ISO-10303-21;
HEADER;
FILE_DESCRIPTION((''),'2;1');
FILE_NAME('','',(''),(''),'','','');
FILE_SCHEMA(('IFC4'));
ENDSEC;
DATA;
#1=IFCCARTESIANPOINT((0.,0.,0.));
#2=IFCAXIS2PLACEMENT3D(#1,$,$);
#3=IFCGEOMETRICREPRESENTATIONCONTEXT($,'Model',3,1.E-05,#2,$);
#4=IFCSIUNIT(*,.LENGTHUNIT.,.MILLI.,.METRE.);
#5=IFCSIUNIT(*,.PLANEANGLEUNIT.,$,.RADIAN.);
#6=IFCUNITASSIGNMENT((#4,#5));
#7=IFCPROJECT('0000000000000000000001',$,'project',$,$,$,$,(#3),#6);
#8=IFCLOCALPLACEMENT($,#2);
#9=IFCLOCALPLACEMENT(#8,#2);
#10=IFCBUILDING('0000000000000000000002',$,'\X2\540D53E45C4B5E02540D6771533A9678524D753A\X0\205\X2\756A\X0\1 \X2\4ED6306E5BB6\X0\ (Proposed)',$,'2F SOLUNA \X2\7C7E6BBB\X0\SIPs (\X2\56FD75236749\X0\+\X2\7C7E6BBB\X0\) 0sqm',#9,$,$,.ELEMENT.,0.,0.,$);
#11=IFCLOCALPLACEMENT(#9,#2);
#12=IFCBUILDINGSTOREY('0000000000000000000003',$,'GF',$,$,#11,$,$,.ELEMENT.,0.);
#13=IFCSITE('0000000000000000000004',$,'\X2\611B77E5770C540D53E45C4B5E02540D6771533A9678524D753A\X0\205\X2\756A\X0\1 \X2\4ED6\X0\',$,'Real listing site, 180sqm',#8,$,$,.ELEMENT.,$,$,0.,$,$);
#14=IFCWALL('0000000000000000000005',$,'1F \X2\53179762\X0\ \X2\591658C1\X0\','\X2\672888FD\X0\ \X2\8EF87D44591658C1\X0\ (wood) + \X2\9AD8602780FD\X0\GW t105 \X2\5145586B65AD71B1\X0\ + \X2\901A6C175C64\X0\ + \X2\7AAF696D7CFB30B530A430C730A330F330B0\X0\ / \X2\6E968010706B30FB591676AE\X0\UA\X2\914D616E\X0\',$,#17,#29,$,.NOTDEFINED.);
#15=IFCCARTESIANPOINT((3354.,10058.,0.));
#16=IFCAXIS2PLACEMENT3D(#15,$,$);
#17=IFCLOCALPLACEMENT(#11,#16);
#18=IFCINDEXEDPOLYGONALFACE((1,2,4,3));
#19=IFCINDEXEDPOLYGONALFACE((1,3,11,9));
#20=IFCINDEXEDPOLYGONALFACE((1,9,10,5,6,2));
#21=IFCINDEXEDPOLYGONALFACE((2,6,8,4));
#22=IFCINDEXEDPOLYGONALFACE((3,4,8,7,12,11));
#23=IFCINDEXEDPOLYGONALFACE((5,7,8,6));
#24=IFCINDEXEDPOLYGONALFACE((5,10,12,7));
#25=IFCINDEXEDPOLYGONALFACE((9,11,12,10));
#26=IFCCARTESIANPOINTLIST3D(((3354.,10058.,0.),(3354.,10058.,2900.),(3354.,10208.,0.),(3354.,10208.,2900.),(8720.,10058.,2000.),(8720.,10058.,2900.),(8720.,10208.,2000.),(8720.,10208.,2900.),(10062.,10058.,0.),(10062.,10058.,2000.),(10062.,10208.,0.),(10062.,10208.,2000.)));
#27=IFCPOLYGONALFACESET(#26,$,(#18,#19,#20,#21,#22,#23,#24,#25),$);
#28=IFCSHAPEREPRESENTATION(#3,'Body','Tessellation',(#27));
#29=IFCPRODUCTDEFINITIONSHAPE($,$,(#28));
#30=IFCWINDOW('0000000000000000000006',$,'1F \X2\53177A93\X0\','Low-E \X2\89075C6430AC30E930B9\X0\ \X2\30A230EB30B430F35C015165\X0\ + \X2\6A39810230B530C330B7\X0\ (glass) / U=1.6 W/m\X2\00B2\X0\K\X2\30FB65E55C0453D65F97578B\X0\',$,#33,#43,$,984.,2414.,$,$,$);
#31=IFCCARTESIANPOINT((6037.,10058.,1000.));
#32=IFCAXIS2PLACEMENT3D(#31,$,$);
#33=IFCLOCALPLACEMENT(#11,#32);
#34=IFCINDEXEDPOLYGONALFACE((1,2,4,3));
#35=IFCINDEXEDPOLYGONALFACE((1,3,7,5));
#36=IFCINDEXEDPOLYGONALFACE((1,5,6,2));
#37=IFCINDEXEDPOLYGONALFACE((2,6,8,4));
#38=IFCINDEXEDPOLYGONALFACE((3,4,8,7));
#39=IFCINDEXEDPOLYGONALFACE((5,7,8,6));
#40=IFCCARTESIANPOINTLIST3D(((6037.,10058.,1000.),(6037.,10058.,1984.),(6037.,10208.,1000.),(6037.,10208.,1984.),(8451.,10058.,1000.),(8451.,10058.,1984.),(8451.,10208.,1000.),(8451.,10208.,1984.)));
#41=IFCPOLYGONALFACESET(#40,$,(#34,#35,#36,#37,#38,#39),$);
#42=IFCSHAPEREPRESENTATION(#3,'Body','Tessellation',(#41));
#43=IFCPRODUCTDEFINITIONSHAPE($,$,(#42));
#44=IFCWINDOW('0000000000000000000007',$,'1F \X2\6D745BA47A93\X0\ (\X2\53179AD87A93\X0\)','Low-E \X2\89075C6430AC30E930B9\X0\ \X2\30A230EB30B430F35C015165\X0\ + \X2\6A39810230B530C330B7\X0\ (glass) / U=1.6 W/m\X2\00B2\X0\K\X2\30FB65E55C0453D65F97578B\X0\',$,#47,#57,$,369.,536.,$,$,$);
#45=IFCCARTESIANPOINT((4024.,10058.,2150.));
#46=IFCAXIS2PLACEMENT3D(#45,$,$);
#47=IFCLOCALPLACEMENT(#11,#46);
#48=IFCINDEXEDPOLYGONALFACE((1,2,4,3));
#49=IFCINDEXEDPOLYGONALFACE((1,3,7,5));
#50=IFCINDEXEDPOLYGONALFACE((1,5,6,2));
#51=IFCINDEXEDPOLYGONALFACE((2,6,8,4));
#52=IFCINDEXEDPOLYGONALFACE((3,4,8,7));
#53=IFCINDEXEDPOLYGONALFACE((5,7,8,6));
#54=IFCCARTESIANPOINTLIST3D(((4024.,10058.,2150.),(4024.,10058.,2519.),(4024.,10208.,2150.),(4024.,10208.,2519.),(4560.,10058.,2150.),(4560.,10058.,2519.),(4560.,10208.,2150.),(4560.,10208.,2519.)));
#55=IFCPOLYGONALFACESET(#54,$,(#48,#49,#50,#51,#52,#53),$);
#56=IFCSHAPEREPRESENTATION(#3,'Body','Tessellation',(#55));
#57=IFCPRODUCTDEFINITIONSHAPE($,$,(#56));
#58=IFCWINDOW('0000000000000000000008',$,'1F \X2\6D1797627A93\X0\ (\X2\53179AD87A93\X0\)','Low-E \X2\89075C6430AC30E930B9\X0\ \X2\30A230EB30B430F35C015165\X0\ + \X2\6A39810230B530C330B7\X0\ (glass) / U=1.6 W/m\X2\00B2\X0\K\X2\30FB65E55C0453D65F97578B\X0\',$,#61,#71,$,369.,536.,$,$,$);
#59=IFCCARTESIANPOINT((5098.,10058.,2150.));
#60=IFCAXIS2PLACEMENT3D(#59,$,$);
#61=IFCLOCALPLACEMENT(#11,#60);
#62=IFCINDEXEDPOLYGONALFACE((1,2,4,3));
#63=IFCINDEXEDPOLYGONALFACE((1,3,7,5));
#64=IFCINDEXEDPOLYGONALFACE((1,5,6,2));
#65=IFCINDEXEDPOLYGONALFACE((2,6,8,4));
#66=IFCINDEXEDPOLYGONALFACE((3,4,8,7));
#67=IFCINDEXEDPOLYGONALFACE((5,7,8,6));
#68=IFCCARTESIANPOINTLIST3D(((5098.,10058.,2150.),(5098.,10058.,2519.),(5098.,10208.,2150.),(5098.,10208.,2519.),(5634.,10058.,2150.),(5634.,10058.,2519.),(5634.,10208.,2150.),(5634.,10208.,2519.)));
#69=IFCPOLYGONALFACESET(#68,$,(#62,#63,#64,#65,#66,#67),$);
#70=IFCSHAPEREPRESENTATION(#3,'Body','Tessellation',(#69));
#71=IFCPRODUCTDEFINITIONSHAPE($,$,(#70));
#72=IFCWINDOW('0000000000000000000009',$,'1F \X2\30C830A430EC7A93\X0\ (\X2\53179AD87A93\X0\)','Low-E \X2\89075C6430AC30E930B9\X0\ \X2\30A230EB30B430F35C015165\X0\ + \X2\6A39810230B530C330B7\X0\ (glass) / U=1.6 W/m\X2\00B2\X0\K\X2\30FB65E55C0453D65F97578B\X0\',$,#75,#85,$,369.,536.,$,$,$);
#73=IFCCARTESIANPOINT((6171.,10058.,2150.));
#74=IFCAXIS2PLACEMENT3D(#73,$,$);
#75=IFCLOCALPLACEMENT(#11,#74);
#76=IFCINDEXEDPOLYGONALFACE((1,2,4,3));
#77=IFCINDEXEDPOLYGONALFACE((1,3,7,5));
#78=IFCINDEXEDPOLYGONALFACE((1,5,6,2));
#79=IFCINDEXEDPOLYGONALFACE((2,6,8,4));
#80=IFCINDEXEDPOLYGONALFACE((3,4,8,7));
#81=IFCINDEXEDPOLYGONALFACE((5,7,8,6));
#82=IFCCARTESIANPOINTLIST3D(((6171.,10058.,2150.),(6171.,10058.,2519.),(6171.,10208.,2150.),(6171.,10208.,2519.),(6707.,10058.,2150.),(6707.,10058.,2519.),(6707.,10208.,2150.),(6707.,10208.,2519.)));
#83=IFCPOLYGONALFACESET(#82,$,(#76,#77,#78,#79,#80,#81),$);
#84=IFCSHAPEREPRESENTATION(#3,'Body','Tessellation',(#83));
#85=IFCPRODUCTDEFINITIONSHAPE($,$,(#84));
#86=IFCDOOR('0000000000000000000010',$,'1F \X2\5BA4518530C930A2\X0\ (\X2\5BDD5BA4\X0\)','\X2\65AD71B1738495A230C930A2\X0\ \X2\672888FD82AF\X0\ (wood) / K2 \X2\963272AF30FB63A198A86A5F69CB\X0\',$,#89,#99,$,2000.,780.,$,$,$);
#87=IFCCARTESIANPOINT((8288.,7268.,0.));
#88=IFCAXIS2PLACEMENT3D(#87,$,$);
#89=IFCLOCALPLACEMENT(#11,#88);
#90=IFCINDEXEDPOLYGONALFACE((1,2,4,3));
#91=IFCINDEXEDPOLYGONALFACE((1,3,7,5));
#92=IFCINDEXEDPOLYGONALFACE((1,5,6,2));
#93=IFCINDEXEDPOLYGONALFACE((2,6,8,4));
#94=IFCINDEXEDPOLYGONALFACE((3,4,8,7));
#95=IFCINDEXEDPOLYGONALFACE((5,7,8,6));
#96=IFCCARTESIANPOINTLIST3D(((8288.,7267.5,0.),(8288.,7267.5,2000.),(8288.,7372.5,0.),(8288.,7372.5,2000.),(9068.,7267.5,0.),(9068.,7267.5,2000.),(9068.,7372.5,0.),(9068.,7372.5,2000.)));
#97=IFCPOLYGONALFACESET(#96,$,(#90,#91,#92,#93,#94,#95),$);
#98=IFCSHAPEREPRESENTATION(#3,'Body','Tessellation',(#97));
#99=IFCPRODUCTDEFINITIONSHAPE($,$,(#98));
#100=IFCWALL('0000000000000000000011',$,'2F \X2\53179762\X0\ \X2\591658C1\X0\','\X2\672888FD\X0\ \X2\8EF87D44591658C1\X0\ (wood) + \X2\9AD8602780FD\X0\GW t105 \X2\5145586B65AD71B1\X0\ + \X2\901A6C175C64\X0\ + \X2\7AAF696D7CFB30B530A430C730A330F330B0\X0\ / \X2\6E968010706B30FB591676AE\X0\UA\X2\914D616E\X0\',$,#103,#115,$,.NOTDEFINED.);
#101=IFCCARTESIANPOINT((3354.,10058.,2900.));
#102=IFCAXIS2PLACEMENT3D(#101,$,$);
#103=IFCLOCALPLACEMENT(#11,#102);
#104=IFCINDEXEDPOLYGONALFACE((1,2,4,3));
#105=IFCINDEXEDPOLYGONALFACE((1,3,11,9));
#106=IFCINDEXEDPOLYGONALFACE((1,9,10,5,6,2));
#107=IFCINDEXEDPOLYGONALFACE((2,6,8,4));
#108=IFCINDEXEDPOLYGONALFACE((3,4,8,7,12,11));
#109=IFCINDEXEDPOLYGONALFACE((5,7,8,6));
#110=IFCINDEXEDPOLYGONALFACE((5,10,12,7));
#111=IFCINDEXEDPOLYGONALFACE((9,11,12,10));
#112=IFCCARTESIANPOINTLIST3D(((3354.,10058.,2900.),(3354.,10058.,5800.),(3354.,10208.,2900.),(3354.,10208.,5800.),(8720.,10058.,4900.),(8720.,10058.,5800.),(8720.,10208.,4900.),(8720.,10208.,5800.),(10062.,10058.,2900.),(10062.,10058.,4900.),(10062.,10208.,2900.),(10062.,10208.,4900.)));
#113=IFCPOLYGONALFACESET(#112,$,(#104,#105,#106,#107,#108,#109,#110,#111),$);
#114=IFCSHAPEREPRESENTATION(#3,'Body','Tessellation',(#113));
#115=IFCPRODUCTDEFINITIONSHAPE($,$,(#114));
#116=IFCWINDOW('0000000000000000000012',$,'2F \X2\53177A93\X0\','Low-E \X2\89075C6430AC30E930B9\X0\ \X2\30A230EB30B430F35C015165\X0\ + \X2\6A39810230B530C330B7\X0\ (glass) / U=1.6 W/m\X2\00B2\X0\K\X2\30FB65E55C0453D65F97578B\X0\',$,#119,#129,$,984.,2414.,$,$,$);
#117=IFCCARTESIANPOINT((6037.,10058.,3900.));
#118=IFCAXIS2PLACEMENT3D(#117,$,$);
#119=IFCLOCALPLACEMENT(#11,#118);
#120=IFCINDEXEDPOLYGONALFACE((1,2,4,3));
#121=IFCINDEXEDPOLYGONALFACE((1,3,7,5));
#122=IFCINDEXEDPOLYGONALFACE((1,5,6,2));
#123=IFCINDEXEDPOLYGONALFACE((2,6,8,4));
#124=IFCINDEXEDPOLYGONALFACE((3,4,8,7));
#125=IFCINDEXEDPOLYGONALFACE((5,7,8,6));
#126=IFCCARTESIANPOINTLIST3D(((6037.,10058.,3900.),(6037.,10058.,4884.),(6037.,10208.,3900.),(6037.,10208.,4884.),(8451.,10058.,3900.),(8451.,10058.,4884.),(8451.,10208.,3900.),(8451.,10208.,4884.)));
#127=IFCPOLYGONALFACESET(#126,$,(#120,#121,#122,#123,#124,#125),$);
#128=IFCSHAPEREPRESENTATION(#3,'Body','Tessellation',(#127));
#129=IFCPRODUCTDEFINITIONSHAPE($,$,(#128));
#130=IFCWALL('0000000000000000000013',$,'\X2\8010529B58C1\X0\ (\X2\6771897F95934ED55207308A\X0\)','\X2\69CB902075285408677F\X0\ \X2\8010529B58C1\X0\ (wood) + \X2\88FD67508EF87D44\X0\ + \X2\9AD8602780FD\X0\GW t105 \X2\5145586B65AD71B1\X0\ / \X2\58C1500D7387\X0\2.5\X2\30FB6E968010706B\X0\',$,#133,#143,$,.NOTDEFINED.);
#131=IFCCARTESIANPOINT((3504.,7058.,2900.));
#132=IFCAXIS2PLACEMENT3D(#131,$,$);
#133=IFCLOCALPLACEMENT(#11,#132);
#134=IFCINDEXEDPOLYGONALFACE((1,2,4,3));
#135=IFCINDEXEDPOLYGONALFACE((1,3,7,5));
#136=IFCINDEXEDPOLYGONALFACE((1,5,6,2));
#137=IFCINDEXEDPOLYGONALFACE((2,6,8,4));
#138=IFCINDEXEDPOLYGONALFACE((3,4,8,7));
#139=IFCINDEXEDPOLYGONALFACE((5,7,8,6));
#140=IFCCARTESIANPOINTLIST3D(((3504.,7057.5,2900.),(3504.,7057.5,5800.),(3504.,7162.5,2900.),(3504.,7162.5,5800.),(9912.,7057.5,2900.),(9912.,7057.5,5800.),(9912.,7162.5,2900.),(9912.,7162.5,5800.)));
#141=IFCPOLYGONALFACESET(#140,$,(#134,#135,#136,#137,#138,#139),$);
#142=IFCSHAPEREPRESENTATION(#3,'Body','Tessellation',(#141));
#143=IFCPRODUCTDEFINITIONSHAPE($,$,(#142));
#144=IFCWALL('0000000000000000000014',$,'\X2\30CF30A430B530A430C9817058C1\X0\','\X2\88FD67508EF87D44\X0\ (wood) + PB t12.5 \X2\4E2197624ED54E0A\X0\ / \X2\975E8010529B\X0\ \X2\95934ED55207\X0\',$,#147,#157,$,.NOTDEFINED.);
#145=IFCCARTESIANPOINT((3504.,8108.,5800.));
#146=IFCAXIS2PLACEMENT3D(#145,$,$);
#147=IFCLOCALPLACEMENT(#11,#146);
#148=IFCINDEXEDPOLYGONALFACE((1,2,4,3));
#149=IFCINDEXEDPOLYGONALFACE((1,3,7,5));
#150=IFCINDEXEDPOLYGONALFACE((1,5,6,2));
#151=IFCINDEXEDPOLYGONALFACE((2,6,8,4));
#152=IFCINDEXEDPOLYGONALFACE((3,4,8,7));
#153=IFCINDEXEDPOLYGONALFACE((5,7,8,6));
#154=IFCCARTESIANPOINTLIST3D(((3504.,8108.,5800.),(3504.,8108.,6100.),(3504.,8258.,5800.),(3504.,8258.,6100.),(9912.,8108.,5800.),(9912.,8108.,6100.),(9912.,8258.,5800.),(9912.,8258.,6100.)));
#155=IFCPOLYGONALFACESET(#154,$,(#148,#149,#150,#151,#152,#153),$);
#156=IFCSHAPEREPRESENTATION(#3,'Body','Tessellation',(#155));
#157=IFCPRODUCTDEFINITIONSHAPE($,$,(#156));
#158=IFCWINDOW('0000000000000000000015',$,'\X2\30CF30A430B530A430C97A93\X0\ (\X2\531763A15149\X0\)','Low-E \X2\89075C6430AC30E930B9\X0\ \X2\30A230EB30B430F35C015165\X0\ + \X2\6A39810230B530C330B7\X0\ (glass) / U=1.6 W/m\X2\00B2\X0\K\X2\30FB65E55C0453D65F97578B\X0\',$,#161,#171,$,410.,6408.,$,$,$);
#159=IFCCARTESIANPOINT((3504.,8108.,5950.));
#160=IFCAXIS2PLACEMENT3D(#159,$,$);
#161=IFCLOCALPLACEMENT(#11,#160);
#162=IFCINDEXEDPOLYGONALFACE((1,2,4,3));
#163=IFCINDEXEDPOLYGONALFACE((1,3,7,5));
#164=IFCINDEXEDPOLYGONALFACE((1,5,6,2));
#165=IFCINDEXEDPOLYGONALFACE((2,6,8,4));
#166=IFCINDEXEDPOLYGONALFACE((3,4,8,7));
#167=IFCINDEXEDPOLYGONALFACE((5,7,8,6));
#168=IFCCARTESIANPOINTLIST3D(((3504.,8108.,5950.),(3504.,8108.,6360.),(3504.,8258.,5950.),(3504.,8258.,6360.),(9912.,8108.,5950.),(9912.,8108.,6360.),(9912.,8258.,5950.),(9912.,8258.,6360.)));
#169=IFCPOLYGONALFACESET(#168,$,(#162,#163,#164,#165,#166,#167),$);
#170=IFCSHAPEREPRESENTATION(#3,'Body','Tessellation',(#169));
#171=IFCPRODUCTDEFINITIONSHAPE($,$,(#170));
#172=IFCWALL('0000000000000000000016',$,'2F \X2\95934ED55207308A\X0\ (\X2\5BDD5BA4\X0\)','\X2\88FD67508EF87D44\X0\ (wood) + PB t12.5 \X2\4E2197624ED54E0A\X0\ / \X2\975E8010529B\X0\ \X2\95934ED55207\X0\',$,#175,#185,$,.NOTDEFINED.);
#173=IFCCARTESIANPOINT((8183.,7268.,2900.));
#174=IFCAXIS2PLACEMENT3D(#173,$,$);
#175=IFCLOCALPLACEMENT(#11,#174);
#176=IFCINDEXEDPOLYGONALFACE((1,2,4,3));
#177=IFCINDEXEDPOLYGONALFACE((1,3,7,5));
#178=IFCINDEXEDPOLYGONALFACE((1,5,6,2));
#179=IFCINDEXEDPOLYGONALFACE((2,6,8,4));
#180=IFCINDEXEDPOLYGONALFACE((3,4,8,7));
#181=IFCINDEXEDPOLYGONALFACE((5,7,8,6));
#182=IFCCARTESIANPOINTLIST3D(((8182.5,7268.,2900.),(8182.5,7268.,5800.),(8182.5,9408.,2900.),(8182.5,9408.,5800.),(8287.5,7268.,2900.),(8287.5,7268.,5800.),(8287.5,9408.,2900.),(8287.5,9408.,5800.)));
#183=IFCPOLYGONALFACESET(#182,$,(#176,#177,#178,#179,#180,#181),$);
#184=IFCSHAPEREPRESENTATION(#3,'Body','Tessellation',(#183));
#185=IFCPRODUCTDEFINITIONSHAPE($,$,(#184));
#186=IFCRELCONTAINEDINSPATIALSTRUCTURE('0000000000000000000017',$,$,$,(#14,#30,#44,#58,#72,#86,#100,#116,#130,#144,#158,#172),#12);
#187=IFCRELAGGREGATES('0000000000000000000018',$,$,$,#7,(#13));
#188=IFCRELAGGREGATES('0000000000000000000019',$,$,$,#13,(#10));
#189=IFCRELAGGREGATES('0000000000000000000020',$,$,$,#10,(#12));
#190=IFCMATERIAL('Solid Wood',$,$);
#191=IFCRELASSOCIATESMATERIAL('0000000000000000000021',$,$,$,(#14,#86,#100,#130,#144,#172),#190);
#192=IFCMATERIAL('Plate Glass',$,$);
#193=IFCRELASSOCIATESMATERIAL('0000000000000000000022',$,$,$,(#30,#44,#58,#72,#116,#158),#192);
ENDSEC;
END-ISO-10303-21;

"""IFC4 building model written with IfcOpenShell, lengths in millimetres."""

from ifc_helpers import new_model, si_unit, frame, frame_2d, origin, place, context, project, spatial, rectangle, extrude, material, element, fill, save


model = new_model("IFC4")

# Units and contexts
model_context = context("Model", 3, precision=1e-05, world=origin())
ifc_project = project(units=[si_unit("LENGTHUNIT", "METRE", prefix="MILLI"), si_unit("PLANEANGLEUNIT", "RADIAN")], contexts=[model_context])

# Site, building, storey
site_placement = place(None, origin())
site = spatial("IfcSite", under=ifc_project, at=site_placement, Name="愛知県名古屋市名東区陸前町205番1 他", ObjectType="Real listing site, 180sqm", CompositionType="ELEMENT", RefElevation=0.0)
building_placement = place(site_placement, origin())
building = spatial("IfcBuilding", under=site, at=building_placement, Name="名古屋市名東区陸前町205番1 他の家 (Proposed)", ObjectType="2F SOLUNA 籾殻SIPs (国産杉+籾殻) 0sqm", CompositionType="ELEMENT", ElevationOfRefHeight=0.0, ElevationOfTerrain=0.0)
storey_placement = place(building_placement, origin())
storey = spatial("IfcBuildingStorey", under=building, at=storey_placement, Name="GF", CompositionType="ELEMENT", Elevation=0.0)

# Wall, openings, windows
ifc_material_1 = material(Name="Solid Wood")
wall_1_placement = place(storey_placement, frame((3354.0, 10058.0, 0.0)))
wall_1 = element("IfcWall", 1, at=wall_1_placement, inside=storey, material=ifc_material_1, Name="1F 北面 外壁", Description="木製 軸組外壁 (wood) + 高性能GW t105 充填断熱 + 通気層 + 窯業系サイディング / 準耐火・外皮UA配慮", PredefinedType="NOTDEFINED", context=model_context, shape_type="SweptSolid", body=[
    extrude(rectangle(XDim=6708.0, YDim=150.0, at=frame_2d((3354.0, 75.0))), frame((3354.0, 10058.0, 0.0)), (0.0, 0.0, 1.0), 2900.0),
])
opening_1_placement = place(storey_placement, frame((6037.0, 10058.0, 1000.0)))
opening_1 = element("IfcOpeningElement", 2, at=opening_1_placement, cuts=wall_1, PredefinedType="NOTDEFINED", context=model_context, shape_type="SweptSolid", body=[
    extrude(rectangle(XDim=2414.0, YDim=150.0, at=frame_2d((1207.0, 75.0))), frame((6037.0, 10058.0, 1000.0)), (0.0, 0.0, 1.0), 984.0),
])
opening_2_placement = place(storey_placement, frame((4024.0, 10058.0, 2150.0)))
opening_2 = element("IfcOpeningElement", 3, at=opening_2_placement, cuts=wall_1, PredefinedType="NOTDEFINED", context=model_context, shape_type="SweptSolid", body=[
    extrude(rectangle(XDim=536.0, YDim=150.0, at=frame_2d((268.0, 75.0))), frame((4024.0, 10058.0, 2150.0)), (0.0, 0.0, 1.0), 369.0),
])
opening_3_placement = place(storey_placement, frame((5098.0, 10058.0, 2150.0)))
opening_3 = element("IfcOpeningElement", 4, at=opening_3_placement, cuts=wall_1, PredefinedType="NOTDEFINED", context=model_context, shape_type="SweptSolid", body=[
    extrude(rectangle(XDim=536.0, YDim=150.0, at=frame_2d((268.0, 75.0))), frame((5098.0, 10058.0, 2150.0)), (0.0, 0.0, 1.0), 369.0),
])
opening_4_placement = place(storey_placement, frame((6171.0, 10058.0, 2150.0)))
opening_4 = element("IfcOpeningElement", 5, at=opening_4_placement, cuts=wall_1, PredefinedType="NOTDEFINED", context=model_context, shape_type="SweptSolid", body=[
    extrude(rectangle(XDim=536.0, YDim=150.0, at=frame_2d((268.0, 75.0))), frame((6171.0, 10058.0, 2150.0)), (0.0, 0.0, 1.0), 369.0),
])
ifc_material_2 = material(Name="Plate Glass")
window_1_placement = place(storey_placement, frame((6037.0, 10058.0, 1000.0)))
window_1 = element("IfcWindow", 6, at=window_1_placement, inside=storey, material=ifc_material_2, Name="1F 北窓", Description="Low-E 複層ガラス アルゴン封入 + 樹脂サッシ (glass) / U=1.6 W/m²K・日射取得型", OverallHeight=984.0, OverallWidth=2414.0, context=model_context, shape_type="SweptSolid", body=[
    extrude(rectangle(XDim=2414.0, YDim=150.0, at=frame_2d((1207.0, 75.0))), frame((6037.0, 10058.0, 1000.0)), (0.0, 0.0, 1.0), 984.0),
])
fill(opening_1, window_1)
window_2_placement = place(storey_placement, frame((4024.0, 10058.0, 2150.0)))
window_2 = element("IfcWindow", 7, at=window_2_placement, inside=storey, material=ifc_material_2, Name="1F 浴室窓 (北高窓)", Description="Low-E 複層ガラス アルゴン封入 + 樹脂サッシ (glass) / U=1.6 W/m²K・日射取得型", OverallHeight=369.0, OverallWidth=536.0, context=model_context, shape_type="SweptSolid", body=[
    extrude(rectangle(XDim=536.0, YDim=150.0, at=frame_2d((268.0, 75.0))), frame((4024.0, 10058.0, 2150.0)), (0.0, 0.0, 1.0), 369.0),
])
fill(opening_2, window_2)
window_3_placement = place(storey_placement, frame((5098.0, 10058.0, 2150.0)))
window_3 = element("IfcWindow", 8, at=window_3_placement, inside=storey, material=ifc_material_2, Name="1F 洗面窓 (北高窓)", Description="Low-E 複層ガラス アルゴン封入 + 樹脂サッシ (glass) / U=1.6 W/m²K・日射取得型", OverallHeight=369.0, OverallWidth=536.0, context=model_context, shape_type="SweptSolid", body=[
    extrude(rectangle(XDim=536.0, YDim=150.0, at=frame_2d((268.0, 75.0))), frame((5098.0, 10058.0, 2150.0)), (0.0, 0.0, 1.0), 369.0),
])
fill(opening_3, window_3)
window_4_placement = place(storey_placement, frame((6171.0, 10058.0, 2150.0)))
window_4 = element("IfcWindow", 9, at=window_4_placement, inside=storey, material=ifc_material_2, Name="1F トイレ窓 (北高窓)", Description="Low-E 複層ガラス アルゴン封入 + 樹脂サッシ (glass) / U=1.6 W/m²K・日射取得型", OverallHeight=369.0, OverallWidth=536.0, context=model_context, shape_type="SweptSolid", body=[
    extrude(rectangle(XDim=536.0, YDim=150.0, at=frame_2d((268.0, 75.0))), frame((6171.0, 10058.0, 2150.0)), (0.0, 0.0, 1.0), 369.0),
])
fill(opening_4, window_4)

# Door
door_1_placement = place(storey_placement, frame((8288.0, 7268.0, 0.0)))
element("IfcDoor", 10, at=door_1_placement, inside=storey, material=ifc_material_1, Name="1F 室内ドア (寝室)", Description="断熱玄関ドア 木製芯 (wood) / K2 防犯・採風機構", OverallHeight=2000.0, OverallWidth=780.0, context=model_context, shape_type="SweptSolid", body=[
    extrude(rectangle(XDim=780.0, YDim=105.0, at=frame_2d((390.0, 52.0))), frame((8288.0, 7268.0, 0.0)), (0.0, 0.0, 1.0), 2000.0),
])

# Wall, opening, window
wall_2_placement = place(storey_placement, frame((3354.0, 10058.0, 2900.0)))
wall_2 = element("IfcWall", 11, at=wall_2_placement, inside=storey, material=ifc_material_1, Name="2F 北面 外壁", Description="木製 軸組外壁 (wood) + 高性能GW t105 充填断熱 + 通気層 + 窯業系サイディング / 準耐火・外皮UA配慮", PredefinedType="NOTDEFINED", context=model_context, shape_type="SweptSolid", body=[
    extrude(rectangle(XDim=6708.0, YDim=150.0, at=frame_2d((3354.0, 75.0))), frame((3354.0, 10058.0, 2900.0)), (0.0, 0.0, 1.0), 2900.0),
])
opening_5_placement = place(storey_placement, frame((6037.0, 10058.0, 3900.0)))
opening_5 = element("IfcOpeningElement", 12, at=opening_5_placement, cuts=wall_2, PredefinedType="NOTDEFINED", context=model_context, shape_type="SweptSolid", body=[
    extrude(rectangle(XDim=2414.0, YDim=150.0, at=frame_2d((1207.0, 75.0))), frame((6037.0, 10058.0, 3900.0)), (0.0, 0.0, 1.0), 984.0),
])
window_5_placement = place(storey_placement, frame((6037.0, 10058.0, 3900.0)))
window_5 = element("IfcWindow", 13, at=window_5_placement, inside=storey, material=ifc_material_2, Name="2F 北窓", Description="Low-E 複層ガラス アルゴン封入 + 樹脂サッシ (glass) / U=1.6 W/m²K・日射取得型", OverallHeight=984.0, OverallWidth=2414.0, context=model_context, shape_type="SweptSolid", body=[
    extrude(rectangle(XDim=2414.0, YDim=150.0, at=frame_2d((1207.0, 75.0))), frame((6037.0, 10058.0, 3900.0)), (0.0, 0.0, 1.0), 984.0),
])
fill(opening_5, window_5)

# Wall
wall_3_placement = place(storey_placement, frame((3504.0, 7058.0, 2900.0)))
element("IfcWall", 14, at=wall_3_placement, inside=storey, material=ifc_material_1, Name="耐力壁 (東西間仕切り)", Description="構造用合板 耐力壁 (wood) + 製材軸組 + 高性能GW t105 充填断熱 / 壁倍率2.5・準耐火", PredefinedType="NOTDEFINED", context=model_context, shape_type="SweptSolid", body=[
    extrude(rectangle(XDim=6408.0, YDim=105.0, at=frame_2d((3204.0, 52.0))), frame((3504.0, 7058.0, 2900.0)), (0.0, 0.0, 1.0), 2900.0),
])

# Wall, opening, window
wall_4_placement = place(storey_placement, frame((3504.0, 8108.0, 5800.0)))
wall_4 = element("IfcWall", 15, at=wall_4_placement, inside=storey, material=ifc_material_1, Name="ハイサイド腰壁", Description="製材軸組 (wood) + PB t12.5 両面仕上 / 非耐力 間仕切", PredefinedType="NOTDEFINED", context=model_context, shape_type="SweptSolid", body=[
    extrude(rectangle(XDim=6408.0, YDim=150.0, at=frame_2d((3204.0, 75.0))), frame((3504.0, 8108.0, 5800.0)), (0.0, 0.0, 1.0), 700.0),
])
opening_6_placement = place(storey_placement, frame((3504.0, 8108.0, 5950.0)))
opening_6 = element("IfcOpeningElement", 16, at=opening_6_placement, cuts=wall_4, PredefinedType="NOTDEFINED", context=model_context, shape_type="SweptSolid", body=[
    extrude(rectangle(XDim=6408.0, YDim=150.0, at=frame_2d((3204.0, 75.0))), frame((3504.0, 8108.0, 5950.0)), (0.0, 0.0, 1.0), 410.0),
])
window_6_placement = place(storey_placement, frame((3504.0, 8108.0, 5950.0)))
window_6 = element("IfcWindow", 17, at=window_6_placement, inside=storey, material=ifc_material_2, Name="ハイサイド窓 (北採光)", Description="Low-E 複層ガラス アルゴン封入 + 樹脂サッシ (glass) / U=1.6 W/m²K・日射取得型", OverallHeight=410.0, OverallWidth=6408.0, context=model_context, shape_type="SweptSolid", body=[
    extrude(rectangle(XDim=6408.0, YDim=150.0, at=frame_2d((3204.0, 75.0))), frame((3504.0, 8108.0, 5950.0)), (0.0, 0.0, 1.0), 410.0),
])
fill(opening_6, window_6)

# Wall
wall_5_placement = place(storey_placement, frame((8183.0, 7268.0, 2900.0)))
element("IfcWall", 18, at=wall_5_placement, inside=storey, material=ifc_material_1, Name="2F 間仕切り (寝室)", Description="製材軸組 (wood) + PB t12.5 両面仕上 / 非耐力 間仕切", PredefinedType="NOTDEFINED", context=model_context, shape_type="SweptSolid", body=[
    extrude(rectangle(XDim=105.0, YDim=2140.0, at=frame_2d((52.0, 1070.0))), frame((8183.0, 7268.0, 2900.0)), (0.0, 0.0, 1.0), 2900.0),
])

save(model, "model.ifc")
